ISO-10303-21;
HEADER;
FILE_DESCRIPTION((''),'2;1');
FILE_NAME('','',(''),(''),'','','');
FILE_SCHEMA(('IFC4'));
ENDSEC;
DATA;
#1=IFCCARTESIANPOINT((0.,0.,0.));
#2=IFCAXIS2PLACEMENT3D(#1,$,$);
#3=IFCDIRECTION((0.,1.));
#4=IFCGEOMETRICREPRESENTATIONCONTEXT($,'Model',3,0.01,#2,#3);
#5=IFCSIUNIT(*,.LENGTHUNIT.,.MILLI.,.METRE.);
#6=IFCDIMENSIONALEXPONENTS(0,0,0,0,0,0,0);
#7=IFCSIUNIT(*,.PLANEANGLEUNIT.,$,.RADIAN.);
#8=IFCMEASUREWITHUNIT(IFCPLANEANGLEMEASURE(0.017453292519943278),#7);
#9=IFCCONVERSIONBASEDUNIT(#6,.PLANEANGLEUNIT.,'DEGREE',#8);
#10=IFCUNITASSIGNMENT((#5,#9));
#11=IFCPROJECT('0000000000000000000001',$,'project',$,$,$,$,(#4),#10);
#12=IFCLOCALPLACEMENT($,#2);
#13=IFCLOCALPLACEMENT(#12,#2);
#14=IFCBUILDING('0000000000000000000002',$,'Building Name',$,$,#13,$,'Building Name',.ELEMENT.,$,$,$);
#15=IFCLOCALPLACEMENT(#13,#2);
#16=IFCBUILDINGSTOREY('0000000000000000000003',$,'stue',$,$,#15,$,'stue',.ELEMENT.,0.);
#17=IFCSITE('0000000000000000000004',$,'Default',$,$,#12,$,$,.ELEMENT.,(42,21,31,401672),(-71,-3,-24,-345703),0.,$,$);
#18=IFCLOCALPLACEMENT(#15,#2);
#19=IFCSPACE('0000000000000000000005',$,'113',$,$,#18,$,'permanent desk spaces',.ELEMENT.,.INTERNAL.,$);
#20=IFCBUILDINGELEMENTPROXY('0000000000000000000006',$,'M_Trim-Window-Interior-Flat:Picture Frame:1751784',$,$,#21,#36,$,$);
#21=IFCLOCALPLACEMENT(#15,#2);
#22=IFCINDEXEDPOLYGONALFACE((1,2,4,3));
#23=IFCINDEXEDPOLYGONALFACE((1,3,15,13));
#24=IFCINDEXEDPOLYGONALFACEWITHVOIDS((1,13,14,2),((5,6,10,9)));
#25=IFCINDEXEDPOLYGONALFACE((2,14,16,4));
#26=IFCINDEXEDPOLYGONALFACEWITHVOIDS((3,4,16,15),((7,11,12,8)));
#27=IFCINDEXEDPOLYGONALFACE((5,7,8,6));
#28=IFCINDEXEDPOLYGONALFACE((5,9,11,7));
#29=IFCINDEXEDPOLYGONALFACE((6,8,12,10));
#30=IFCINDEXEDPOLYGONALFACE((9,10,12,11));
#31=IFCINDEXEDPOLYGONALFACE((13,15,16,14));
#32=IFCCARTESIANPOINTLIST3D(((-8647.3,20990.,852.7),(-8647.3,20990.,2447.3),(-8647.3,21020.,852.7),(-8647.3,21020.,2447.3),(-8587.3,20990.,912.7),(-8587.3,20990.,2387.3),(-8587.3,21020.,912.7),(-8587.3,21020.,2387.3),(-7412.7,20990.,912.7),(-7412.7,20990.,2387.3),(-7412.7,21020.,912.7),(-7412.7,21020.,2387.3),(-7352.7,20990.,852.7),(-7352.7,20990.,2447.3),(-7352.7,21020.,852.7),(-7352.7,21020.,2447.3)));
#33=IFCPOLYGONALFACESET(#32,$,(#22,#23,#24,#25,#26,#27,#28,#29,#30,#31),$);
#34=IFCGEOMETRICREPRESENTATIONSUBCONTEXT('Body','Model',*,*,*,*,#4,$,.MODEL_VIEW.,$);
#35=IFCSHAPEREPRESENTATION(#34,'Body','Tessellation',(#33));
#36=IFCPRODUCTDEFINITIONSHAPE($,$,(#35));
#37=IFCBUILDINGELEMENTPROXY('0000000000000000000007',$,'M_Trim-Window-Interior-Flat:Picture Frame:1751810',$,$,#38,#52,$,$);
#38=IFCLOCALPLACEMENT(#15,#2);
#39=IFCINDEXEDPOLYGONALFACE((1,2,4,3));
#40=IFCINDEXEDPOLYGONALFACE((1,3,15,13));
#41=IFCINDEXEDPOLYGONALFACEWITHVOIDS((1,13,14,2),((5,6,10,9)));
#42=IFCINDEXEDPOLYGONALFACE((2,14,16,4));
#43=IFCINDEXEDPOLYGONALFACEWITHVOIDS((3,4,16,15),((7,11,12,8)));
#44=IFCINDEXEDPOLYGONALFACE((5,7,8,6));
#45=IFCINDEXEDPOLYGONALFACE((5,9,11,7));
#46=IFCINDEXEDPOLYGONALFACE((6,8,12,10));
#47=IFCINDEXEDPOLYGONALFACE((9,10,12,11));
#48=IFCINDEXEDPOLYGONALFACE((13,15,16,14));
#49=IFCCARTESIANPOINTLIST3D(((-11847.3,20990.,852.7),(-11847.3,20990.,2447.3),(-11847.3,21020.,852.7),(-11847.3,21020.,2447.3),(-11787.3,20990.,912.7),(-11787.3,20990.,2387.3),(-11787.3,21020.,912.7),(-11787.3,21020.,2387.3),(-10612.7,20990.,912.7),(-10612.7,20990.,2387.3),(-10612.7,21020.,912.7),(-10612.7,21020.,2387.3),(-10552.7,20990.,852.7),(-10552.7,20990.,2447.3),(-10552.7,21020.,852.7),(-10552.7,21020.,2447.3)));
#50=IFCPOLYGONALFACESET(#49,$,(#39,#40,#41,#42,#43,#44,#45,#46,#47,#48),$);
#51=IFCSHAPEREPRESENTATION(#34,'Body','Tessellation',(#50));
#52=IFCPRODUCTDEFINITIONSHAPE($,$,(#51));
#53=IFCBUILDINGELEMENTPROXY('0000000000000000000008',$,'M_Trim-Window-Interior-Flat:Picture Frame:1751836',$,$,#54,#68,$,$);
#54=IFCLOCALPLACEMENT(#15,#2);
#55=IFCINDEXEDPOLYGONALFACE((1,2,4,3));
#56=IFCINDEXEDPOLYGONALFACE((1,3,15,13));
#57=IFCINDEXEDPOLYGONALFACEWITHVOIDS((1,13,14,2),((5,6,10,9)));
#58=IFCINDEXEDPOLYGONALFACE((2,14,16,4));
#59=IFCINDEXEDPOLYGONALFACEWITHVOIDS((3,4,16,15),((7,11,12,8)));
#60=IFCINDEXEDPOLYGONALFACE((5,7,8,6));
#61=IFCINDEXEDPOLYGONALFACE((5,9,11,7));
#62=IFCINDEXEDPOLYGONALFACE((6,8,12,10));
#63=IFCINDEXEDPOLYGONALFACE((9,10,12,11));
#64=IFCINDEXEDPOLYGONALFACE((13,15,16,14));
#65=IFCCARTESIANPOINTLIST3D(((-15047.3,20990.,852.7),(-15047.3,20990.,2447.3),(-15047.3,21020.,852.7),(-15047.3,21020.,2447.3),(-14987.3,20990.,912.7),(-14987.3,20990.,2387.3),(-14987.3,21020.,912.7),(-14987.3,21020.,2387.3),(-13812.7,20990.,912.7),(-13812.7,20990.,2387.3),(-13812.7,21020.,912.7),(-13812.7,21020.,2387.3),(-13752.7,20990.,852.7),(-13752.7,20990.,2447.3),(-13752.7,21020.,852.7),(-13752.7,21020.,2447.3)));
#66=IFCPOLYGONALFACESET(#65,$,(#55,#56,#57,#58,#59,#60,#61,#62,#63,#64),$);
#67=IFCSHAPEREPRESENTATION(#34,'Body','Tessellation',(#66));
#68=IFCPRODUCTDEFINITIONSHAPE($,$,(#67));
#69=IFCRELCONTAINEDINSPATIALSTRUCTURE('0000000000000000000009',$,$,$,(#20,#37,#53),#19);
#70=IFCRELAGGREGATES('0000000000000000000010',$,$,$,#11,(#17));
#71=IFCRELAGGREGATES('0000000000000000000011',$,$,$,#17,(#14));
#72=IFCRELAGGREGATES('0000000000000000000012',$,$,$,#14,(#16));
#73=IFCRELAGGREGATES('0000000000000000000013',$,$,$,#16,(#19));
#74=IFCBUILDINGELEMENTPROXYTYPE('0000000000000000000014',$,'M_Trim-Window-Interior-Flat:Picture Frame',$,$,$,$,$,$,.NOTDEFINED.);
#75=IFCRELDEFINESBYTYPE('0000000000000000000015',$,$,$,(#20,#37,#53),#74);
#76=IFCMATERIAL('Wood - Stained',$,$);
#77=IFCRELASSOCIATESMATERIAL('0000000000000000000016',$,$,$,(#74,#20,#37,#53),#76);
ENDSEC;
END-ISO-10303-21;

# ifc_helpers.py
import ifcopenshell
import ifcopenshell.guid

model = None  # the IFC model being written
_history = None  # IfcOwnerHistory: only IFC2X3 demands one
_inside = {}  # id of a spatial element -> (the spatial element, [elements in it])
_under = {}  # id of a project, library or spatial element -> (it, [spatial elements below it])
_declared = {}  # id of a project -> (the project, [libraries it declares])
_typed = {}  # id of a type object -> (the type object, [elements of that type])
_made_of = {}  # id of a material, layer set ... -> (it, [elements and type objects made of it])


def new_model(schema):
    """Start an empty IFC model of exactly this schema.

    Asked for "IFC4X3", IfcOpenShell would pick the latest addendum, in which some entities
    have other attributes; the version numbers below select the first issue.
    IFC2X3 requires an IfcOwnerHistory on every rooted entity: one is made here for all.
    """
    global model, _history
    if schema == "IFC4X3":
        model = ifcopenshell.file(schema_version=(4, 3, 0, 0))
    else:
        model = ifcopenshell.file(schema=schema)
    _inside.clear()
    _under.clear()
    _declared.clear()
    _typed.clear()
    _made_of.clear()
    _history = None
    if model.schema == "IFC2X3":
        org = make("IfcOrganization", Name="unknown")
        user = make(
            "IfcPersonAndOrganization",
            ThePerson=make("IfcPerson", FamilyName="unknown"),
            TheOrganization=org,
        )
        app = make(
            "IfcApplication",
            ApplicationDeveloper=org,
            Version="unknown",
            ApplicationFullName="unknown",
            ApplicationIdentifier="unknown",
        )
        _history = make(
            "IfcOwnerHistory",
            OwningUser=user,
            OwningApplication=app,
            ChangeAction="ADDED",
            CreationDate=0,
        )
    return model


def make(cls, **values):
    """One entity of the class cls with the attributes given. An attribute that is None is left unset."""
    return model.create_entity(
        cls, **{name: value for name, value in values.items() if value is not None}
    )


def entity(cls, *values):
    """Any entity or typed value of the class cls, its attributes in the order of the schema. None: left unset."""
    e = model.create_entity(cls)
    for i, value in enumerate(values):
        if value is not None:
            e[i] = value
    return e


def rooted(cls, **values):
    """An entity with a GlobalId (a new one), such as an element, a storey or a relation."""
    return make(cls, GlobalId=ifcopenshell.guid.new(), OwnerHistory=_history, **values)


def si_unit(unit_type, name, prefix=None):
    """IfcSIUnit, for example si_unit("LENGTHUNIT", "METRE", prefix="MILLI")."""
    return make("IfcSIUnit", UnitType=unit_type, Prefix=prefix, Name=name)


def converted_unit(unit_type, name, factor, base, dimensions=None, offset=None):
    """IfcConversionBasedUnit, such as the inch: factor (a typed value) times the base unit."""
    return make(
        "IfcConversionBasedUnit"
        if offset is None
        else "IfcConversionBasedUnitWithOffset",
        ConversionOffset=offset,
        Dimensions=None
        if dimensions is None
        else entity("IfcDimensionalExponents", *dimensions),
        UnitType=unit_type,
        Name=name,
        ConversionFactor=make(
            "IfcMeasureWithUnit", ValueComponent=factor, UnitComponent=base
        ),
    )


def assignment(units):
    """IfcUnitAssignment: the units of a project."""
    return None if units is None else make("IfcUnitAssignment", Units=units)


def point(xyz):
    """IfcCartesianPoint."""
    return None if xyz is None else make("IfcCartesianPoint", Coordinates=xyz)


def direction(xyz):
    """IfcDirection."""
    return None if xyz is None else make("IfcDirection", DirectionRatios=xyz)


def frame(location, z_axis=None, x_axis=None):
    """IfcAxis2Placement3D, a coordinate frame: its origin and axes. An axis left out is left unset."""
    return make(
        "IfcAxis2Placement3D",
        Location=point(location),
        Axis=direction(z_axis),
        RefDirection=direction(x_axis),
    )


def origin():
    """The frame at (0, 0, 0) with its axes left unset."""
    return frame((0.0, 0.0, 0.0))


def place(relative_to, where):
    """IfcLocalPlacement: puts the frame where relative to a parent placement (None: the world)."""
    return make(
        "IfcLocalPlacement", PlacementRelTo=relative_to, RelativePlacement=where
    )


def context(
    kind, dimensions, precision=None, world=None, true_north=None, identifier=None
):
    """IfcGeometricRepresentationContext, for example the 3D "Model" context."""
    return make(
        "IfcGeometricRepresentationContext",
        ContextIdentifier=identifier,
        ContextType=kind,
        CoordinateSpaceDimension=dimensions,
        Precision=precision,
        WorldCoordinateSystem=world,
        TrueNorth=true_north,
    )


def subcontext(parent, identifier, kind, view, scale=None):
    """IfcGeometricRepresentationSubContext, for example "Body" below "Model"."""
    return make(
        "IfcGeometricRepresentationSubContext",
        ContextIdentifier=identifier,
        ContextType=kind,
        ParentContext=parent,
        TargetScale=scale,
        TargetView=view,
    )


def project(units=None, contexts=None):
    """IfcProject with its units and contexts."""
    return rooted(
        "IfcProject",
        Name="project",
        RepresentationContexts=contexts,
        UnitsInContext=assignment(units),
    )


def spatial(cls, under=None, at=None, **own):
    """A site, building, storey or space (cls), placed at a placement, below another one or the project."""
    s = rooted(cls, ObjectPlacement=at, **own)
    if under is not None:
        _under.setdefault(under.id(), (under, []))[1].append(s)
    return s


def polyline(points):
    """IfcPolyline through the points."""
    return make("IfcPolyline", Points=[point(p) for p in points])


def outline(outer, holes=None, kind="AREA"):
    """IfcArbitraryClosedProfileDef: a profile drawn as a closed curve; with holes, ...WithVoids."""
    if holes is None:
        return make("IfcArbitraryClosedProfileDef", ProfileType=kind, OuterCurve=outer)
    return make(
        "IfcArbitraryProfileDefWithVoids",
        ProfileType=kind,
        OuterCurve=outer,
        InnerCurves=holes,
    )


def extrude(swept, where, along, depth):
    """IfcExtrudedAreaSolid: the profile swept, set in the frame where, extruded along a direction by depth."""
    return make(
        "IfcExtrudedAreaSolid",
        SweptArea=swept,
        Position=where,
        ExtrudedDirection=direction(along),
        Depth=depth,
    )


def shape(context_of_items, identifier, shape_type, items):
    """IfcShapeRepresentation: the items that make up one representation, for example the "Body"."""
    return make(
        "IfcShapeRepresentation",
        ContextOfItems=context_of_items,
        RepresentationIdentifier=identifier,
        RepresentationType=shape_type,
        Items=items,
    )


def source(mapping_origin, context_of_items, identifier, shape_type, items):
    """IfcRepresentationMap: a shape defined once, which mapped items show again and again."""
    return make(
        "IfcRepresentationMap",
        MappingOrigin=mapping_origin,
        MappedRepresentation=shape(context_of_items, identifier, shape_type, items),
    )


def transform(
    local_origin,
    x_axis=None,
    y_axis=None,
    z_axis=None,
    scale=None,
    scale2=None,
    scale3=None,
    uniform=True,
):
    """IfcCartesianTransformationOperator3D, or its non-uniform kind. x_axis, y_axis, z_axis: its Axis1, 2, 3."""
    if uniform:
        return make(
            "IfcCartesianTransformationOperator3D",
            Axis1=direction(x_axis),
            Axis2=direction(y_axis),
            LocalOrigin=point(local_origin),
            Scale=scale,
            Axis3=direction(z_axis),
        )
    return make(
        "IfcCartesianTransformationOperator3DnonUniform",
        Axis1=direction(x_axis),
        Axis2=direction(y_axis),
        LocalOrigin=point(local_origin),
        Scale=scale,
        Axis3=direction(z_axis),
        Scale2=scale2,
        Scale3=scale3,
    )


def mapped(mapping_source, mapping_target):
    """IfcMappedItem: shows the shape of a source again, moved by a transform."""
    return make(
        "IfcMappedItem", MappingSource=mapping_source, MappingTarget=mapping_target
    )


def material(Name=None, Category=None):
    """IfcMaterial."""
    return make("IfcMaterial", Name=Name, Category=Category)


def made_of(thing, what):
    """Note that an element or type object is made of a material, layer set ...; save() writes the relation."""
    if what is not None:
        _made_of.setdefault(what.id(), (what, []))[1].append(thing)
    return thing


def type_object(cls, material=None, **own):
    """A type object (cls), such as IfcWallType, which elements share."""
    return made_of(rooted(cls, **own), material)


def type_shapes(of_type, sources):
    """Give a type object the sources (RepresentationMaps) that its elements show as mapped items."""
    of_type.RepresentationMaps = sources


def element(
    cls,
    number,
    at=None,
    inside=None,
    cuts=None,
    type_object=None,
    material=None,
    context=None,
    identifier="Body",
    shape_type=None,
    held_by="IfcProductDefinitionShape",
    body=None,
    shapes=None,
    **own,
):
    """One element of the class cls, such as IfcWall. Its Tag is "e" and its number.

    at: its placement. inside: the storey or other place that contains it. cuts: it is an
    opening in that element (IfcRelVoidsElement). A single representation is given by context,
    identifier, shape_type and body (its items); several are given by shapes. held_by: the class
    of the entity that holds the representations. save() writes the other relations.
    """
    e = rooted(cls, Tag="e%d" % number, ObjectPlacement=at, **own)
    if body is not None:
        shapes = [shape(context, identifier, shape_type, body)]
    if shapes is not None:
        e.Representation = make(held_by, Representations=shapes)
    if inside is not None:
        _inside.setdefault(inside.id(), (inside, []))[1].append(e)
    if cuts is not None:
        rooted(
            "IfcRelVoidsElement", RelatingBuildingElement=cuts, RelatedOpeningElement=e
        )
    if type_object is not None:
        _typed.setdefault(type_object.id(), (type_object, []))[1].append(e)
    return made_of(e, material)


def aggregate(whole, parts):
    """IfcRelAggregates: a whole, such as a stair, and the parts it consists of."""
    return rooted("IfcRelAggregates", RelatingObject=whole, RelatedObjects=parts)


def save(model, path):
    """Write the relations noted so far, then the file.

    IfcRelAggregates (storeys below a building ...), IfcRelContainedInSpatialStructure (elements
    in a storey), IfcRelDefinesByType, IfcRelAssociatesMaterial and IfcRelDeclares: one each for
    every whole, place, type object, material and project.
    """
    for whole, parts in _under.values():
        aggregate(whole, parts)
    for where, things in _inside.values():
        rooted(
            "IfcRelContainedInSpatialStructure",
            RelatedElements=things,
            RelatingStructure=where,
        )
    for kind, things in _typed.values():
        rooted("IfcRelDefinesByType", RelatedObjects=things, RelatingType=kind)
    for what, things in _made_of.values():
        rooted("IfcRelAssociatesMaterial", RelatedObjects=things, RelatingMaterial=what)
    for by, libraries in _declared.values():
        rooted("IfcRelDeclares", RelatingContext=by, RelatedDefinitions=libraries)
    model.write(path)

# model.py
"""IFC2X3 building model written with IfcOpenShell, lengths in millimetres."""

from ifc_helpers import new_model, entity, si_unit, converted_unit, direction, frame, origin, place, context, subcontext, project, spatial, polyline, outline, extrude, source, transform, mapped, material, type_object, type_shapes, element, save


model = new_model("IFC2X3")

# Units and contexts
model_context = context("Model", 3, precision=0.01, world=origin(), true_north=direction((0.0, 1.0)))
body_context = subcontext(model_context, "Body", "Model", "MODEL_VIEW")
ifc_project = project(units=[si_unit("LENGTHUNIT", "METRE", prefix="MILLI"), converted_unit("PLANEANGLEUNIT", "DEGREE", entity("IfcPlaneAngleMeasure", 0.017453292519943278), si_unit("PLANEANGLEUNIT", "RADIAN"), dimensions=[0, 0, 0, 0, 0, 0, 0])], contexts=[model_context])

# Site, building, storey
site_placement = place(None, origin())
site = spatial("IfcSite", under=ifc_project, at=site_placement, Name="Default", CompositionType="ELEMENT", RefLatitude=(42, 21, 31, 401672), RefLongitude=(-71, -3, -24, -345703), RefElevation=0.0)
building_placement = place(site_placement, origin())
building = spatial("IfcBuilding", under=site, at=building_placement, Name="Building Name", LongName="Building Name", CompositionType="ELEMENT")
storey_placement = place(building_placement, origin())
storey = spatial("IfcBuildingStorey", under=building, at=storey_placement, Name="stue", LongName="stue", CompositionType="ELEMENT", Elevation=0.0)

# Shared definitions
ifc_material_1 = material(Name="Wood - Stained")

# Shared definitions
building_element_proxy_type_1 = type_object("IfcBuildingElementProxyType", Name="M_Trim-Window-Interior-Flat:Picture Frame", PredefinedType="NOTDEFINED", material=ifc_material_1)
shared_shape_1 = source(origin(), body_context, "Body", "SweptSolid", [
    extrude(outline(polyline([(-647.3, -797.3), (647.3, -797.3), (647.3, 797.3), (-647.3, 797.3), (-647.3, -797.3)]), holes=[polyline([(-587.3, -737.3), (-587.3, 737.3), (587.3, 737.3), (587.3, -737.3), (-587.3, -737.3)])]), frame((0.0, -750.0, 0.0), z_axis=(0.0, 0.0, 1.0), x_axis=(-1.0, 0.0, 0.0)), (0.0, 0.0, 1.0), 30.0),
])
type_shapes(building_element_proxy_type_1, [shared_shape_1])

# Shared definitions
space_1_placement = place(storey_placement, origin())
space_1 = spatial("IfcSpace", under=storey, at=space_1_placement, Name="113", LongName="permanent desk spaces", CompositionType="ELEMENT", InteriorOrExteriorSpace="INTERNAL")

# Building element proxies
for number, where, z_axis, x_axis, name in (
    (1, (-8000.0, 21020.0, 2400.0), (0.0, -1.0, 0.0), (1.0, 0.0, 0.0), "M_Trim-Window-Interior-Flat:Picture Frame:1751784"),
    (2, (-11200.0, 21020.0, 2400.0), (0.0, -1.0, 0.0), (1.0, 0.0, 0.0), "M_Trim-Window-Interior-Flat:Picture Frame:1751810"),
    (3, (-14400.0, 21020.0, 2400.0), (0.0, -1.0, 0.0), (1.0, 0.0, 0.0), "M_Trim-Window-Interior-Flat:Picture Frame:1751836"),
):
    element("IfcBuildingElementProxy", number, at=place(space_1_placement, frame(where, z_axis=z_axis, x_axis=x_axis)), inside=space_1, type_object=building_element_proxy_type_1, material=ifc_material_1, Name=name, context=body_context, shape_type="MappedRepresentation", body=[
        mapped(shared_shape_1, transform((0.0, 0.0, 0.0), scale=1.0)),
    ])

save(model, "model.ifc")
